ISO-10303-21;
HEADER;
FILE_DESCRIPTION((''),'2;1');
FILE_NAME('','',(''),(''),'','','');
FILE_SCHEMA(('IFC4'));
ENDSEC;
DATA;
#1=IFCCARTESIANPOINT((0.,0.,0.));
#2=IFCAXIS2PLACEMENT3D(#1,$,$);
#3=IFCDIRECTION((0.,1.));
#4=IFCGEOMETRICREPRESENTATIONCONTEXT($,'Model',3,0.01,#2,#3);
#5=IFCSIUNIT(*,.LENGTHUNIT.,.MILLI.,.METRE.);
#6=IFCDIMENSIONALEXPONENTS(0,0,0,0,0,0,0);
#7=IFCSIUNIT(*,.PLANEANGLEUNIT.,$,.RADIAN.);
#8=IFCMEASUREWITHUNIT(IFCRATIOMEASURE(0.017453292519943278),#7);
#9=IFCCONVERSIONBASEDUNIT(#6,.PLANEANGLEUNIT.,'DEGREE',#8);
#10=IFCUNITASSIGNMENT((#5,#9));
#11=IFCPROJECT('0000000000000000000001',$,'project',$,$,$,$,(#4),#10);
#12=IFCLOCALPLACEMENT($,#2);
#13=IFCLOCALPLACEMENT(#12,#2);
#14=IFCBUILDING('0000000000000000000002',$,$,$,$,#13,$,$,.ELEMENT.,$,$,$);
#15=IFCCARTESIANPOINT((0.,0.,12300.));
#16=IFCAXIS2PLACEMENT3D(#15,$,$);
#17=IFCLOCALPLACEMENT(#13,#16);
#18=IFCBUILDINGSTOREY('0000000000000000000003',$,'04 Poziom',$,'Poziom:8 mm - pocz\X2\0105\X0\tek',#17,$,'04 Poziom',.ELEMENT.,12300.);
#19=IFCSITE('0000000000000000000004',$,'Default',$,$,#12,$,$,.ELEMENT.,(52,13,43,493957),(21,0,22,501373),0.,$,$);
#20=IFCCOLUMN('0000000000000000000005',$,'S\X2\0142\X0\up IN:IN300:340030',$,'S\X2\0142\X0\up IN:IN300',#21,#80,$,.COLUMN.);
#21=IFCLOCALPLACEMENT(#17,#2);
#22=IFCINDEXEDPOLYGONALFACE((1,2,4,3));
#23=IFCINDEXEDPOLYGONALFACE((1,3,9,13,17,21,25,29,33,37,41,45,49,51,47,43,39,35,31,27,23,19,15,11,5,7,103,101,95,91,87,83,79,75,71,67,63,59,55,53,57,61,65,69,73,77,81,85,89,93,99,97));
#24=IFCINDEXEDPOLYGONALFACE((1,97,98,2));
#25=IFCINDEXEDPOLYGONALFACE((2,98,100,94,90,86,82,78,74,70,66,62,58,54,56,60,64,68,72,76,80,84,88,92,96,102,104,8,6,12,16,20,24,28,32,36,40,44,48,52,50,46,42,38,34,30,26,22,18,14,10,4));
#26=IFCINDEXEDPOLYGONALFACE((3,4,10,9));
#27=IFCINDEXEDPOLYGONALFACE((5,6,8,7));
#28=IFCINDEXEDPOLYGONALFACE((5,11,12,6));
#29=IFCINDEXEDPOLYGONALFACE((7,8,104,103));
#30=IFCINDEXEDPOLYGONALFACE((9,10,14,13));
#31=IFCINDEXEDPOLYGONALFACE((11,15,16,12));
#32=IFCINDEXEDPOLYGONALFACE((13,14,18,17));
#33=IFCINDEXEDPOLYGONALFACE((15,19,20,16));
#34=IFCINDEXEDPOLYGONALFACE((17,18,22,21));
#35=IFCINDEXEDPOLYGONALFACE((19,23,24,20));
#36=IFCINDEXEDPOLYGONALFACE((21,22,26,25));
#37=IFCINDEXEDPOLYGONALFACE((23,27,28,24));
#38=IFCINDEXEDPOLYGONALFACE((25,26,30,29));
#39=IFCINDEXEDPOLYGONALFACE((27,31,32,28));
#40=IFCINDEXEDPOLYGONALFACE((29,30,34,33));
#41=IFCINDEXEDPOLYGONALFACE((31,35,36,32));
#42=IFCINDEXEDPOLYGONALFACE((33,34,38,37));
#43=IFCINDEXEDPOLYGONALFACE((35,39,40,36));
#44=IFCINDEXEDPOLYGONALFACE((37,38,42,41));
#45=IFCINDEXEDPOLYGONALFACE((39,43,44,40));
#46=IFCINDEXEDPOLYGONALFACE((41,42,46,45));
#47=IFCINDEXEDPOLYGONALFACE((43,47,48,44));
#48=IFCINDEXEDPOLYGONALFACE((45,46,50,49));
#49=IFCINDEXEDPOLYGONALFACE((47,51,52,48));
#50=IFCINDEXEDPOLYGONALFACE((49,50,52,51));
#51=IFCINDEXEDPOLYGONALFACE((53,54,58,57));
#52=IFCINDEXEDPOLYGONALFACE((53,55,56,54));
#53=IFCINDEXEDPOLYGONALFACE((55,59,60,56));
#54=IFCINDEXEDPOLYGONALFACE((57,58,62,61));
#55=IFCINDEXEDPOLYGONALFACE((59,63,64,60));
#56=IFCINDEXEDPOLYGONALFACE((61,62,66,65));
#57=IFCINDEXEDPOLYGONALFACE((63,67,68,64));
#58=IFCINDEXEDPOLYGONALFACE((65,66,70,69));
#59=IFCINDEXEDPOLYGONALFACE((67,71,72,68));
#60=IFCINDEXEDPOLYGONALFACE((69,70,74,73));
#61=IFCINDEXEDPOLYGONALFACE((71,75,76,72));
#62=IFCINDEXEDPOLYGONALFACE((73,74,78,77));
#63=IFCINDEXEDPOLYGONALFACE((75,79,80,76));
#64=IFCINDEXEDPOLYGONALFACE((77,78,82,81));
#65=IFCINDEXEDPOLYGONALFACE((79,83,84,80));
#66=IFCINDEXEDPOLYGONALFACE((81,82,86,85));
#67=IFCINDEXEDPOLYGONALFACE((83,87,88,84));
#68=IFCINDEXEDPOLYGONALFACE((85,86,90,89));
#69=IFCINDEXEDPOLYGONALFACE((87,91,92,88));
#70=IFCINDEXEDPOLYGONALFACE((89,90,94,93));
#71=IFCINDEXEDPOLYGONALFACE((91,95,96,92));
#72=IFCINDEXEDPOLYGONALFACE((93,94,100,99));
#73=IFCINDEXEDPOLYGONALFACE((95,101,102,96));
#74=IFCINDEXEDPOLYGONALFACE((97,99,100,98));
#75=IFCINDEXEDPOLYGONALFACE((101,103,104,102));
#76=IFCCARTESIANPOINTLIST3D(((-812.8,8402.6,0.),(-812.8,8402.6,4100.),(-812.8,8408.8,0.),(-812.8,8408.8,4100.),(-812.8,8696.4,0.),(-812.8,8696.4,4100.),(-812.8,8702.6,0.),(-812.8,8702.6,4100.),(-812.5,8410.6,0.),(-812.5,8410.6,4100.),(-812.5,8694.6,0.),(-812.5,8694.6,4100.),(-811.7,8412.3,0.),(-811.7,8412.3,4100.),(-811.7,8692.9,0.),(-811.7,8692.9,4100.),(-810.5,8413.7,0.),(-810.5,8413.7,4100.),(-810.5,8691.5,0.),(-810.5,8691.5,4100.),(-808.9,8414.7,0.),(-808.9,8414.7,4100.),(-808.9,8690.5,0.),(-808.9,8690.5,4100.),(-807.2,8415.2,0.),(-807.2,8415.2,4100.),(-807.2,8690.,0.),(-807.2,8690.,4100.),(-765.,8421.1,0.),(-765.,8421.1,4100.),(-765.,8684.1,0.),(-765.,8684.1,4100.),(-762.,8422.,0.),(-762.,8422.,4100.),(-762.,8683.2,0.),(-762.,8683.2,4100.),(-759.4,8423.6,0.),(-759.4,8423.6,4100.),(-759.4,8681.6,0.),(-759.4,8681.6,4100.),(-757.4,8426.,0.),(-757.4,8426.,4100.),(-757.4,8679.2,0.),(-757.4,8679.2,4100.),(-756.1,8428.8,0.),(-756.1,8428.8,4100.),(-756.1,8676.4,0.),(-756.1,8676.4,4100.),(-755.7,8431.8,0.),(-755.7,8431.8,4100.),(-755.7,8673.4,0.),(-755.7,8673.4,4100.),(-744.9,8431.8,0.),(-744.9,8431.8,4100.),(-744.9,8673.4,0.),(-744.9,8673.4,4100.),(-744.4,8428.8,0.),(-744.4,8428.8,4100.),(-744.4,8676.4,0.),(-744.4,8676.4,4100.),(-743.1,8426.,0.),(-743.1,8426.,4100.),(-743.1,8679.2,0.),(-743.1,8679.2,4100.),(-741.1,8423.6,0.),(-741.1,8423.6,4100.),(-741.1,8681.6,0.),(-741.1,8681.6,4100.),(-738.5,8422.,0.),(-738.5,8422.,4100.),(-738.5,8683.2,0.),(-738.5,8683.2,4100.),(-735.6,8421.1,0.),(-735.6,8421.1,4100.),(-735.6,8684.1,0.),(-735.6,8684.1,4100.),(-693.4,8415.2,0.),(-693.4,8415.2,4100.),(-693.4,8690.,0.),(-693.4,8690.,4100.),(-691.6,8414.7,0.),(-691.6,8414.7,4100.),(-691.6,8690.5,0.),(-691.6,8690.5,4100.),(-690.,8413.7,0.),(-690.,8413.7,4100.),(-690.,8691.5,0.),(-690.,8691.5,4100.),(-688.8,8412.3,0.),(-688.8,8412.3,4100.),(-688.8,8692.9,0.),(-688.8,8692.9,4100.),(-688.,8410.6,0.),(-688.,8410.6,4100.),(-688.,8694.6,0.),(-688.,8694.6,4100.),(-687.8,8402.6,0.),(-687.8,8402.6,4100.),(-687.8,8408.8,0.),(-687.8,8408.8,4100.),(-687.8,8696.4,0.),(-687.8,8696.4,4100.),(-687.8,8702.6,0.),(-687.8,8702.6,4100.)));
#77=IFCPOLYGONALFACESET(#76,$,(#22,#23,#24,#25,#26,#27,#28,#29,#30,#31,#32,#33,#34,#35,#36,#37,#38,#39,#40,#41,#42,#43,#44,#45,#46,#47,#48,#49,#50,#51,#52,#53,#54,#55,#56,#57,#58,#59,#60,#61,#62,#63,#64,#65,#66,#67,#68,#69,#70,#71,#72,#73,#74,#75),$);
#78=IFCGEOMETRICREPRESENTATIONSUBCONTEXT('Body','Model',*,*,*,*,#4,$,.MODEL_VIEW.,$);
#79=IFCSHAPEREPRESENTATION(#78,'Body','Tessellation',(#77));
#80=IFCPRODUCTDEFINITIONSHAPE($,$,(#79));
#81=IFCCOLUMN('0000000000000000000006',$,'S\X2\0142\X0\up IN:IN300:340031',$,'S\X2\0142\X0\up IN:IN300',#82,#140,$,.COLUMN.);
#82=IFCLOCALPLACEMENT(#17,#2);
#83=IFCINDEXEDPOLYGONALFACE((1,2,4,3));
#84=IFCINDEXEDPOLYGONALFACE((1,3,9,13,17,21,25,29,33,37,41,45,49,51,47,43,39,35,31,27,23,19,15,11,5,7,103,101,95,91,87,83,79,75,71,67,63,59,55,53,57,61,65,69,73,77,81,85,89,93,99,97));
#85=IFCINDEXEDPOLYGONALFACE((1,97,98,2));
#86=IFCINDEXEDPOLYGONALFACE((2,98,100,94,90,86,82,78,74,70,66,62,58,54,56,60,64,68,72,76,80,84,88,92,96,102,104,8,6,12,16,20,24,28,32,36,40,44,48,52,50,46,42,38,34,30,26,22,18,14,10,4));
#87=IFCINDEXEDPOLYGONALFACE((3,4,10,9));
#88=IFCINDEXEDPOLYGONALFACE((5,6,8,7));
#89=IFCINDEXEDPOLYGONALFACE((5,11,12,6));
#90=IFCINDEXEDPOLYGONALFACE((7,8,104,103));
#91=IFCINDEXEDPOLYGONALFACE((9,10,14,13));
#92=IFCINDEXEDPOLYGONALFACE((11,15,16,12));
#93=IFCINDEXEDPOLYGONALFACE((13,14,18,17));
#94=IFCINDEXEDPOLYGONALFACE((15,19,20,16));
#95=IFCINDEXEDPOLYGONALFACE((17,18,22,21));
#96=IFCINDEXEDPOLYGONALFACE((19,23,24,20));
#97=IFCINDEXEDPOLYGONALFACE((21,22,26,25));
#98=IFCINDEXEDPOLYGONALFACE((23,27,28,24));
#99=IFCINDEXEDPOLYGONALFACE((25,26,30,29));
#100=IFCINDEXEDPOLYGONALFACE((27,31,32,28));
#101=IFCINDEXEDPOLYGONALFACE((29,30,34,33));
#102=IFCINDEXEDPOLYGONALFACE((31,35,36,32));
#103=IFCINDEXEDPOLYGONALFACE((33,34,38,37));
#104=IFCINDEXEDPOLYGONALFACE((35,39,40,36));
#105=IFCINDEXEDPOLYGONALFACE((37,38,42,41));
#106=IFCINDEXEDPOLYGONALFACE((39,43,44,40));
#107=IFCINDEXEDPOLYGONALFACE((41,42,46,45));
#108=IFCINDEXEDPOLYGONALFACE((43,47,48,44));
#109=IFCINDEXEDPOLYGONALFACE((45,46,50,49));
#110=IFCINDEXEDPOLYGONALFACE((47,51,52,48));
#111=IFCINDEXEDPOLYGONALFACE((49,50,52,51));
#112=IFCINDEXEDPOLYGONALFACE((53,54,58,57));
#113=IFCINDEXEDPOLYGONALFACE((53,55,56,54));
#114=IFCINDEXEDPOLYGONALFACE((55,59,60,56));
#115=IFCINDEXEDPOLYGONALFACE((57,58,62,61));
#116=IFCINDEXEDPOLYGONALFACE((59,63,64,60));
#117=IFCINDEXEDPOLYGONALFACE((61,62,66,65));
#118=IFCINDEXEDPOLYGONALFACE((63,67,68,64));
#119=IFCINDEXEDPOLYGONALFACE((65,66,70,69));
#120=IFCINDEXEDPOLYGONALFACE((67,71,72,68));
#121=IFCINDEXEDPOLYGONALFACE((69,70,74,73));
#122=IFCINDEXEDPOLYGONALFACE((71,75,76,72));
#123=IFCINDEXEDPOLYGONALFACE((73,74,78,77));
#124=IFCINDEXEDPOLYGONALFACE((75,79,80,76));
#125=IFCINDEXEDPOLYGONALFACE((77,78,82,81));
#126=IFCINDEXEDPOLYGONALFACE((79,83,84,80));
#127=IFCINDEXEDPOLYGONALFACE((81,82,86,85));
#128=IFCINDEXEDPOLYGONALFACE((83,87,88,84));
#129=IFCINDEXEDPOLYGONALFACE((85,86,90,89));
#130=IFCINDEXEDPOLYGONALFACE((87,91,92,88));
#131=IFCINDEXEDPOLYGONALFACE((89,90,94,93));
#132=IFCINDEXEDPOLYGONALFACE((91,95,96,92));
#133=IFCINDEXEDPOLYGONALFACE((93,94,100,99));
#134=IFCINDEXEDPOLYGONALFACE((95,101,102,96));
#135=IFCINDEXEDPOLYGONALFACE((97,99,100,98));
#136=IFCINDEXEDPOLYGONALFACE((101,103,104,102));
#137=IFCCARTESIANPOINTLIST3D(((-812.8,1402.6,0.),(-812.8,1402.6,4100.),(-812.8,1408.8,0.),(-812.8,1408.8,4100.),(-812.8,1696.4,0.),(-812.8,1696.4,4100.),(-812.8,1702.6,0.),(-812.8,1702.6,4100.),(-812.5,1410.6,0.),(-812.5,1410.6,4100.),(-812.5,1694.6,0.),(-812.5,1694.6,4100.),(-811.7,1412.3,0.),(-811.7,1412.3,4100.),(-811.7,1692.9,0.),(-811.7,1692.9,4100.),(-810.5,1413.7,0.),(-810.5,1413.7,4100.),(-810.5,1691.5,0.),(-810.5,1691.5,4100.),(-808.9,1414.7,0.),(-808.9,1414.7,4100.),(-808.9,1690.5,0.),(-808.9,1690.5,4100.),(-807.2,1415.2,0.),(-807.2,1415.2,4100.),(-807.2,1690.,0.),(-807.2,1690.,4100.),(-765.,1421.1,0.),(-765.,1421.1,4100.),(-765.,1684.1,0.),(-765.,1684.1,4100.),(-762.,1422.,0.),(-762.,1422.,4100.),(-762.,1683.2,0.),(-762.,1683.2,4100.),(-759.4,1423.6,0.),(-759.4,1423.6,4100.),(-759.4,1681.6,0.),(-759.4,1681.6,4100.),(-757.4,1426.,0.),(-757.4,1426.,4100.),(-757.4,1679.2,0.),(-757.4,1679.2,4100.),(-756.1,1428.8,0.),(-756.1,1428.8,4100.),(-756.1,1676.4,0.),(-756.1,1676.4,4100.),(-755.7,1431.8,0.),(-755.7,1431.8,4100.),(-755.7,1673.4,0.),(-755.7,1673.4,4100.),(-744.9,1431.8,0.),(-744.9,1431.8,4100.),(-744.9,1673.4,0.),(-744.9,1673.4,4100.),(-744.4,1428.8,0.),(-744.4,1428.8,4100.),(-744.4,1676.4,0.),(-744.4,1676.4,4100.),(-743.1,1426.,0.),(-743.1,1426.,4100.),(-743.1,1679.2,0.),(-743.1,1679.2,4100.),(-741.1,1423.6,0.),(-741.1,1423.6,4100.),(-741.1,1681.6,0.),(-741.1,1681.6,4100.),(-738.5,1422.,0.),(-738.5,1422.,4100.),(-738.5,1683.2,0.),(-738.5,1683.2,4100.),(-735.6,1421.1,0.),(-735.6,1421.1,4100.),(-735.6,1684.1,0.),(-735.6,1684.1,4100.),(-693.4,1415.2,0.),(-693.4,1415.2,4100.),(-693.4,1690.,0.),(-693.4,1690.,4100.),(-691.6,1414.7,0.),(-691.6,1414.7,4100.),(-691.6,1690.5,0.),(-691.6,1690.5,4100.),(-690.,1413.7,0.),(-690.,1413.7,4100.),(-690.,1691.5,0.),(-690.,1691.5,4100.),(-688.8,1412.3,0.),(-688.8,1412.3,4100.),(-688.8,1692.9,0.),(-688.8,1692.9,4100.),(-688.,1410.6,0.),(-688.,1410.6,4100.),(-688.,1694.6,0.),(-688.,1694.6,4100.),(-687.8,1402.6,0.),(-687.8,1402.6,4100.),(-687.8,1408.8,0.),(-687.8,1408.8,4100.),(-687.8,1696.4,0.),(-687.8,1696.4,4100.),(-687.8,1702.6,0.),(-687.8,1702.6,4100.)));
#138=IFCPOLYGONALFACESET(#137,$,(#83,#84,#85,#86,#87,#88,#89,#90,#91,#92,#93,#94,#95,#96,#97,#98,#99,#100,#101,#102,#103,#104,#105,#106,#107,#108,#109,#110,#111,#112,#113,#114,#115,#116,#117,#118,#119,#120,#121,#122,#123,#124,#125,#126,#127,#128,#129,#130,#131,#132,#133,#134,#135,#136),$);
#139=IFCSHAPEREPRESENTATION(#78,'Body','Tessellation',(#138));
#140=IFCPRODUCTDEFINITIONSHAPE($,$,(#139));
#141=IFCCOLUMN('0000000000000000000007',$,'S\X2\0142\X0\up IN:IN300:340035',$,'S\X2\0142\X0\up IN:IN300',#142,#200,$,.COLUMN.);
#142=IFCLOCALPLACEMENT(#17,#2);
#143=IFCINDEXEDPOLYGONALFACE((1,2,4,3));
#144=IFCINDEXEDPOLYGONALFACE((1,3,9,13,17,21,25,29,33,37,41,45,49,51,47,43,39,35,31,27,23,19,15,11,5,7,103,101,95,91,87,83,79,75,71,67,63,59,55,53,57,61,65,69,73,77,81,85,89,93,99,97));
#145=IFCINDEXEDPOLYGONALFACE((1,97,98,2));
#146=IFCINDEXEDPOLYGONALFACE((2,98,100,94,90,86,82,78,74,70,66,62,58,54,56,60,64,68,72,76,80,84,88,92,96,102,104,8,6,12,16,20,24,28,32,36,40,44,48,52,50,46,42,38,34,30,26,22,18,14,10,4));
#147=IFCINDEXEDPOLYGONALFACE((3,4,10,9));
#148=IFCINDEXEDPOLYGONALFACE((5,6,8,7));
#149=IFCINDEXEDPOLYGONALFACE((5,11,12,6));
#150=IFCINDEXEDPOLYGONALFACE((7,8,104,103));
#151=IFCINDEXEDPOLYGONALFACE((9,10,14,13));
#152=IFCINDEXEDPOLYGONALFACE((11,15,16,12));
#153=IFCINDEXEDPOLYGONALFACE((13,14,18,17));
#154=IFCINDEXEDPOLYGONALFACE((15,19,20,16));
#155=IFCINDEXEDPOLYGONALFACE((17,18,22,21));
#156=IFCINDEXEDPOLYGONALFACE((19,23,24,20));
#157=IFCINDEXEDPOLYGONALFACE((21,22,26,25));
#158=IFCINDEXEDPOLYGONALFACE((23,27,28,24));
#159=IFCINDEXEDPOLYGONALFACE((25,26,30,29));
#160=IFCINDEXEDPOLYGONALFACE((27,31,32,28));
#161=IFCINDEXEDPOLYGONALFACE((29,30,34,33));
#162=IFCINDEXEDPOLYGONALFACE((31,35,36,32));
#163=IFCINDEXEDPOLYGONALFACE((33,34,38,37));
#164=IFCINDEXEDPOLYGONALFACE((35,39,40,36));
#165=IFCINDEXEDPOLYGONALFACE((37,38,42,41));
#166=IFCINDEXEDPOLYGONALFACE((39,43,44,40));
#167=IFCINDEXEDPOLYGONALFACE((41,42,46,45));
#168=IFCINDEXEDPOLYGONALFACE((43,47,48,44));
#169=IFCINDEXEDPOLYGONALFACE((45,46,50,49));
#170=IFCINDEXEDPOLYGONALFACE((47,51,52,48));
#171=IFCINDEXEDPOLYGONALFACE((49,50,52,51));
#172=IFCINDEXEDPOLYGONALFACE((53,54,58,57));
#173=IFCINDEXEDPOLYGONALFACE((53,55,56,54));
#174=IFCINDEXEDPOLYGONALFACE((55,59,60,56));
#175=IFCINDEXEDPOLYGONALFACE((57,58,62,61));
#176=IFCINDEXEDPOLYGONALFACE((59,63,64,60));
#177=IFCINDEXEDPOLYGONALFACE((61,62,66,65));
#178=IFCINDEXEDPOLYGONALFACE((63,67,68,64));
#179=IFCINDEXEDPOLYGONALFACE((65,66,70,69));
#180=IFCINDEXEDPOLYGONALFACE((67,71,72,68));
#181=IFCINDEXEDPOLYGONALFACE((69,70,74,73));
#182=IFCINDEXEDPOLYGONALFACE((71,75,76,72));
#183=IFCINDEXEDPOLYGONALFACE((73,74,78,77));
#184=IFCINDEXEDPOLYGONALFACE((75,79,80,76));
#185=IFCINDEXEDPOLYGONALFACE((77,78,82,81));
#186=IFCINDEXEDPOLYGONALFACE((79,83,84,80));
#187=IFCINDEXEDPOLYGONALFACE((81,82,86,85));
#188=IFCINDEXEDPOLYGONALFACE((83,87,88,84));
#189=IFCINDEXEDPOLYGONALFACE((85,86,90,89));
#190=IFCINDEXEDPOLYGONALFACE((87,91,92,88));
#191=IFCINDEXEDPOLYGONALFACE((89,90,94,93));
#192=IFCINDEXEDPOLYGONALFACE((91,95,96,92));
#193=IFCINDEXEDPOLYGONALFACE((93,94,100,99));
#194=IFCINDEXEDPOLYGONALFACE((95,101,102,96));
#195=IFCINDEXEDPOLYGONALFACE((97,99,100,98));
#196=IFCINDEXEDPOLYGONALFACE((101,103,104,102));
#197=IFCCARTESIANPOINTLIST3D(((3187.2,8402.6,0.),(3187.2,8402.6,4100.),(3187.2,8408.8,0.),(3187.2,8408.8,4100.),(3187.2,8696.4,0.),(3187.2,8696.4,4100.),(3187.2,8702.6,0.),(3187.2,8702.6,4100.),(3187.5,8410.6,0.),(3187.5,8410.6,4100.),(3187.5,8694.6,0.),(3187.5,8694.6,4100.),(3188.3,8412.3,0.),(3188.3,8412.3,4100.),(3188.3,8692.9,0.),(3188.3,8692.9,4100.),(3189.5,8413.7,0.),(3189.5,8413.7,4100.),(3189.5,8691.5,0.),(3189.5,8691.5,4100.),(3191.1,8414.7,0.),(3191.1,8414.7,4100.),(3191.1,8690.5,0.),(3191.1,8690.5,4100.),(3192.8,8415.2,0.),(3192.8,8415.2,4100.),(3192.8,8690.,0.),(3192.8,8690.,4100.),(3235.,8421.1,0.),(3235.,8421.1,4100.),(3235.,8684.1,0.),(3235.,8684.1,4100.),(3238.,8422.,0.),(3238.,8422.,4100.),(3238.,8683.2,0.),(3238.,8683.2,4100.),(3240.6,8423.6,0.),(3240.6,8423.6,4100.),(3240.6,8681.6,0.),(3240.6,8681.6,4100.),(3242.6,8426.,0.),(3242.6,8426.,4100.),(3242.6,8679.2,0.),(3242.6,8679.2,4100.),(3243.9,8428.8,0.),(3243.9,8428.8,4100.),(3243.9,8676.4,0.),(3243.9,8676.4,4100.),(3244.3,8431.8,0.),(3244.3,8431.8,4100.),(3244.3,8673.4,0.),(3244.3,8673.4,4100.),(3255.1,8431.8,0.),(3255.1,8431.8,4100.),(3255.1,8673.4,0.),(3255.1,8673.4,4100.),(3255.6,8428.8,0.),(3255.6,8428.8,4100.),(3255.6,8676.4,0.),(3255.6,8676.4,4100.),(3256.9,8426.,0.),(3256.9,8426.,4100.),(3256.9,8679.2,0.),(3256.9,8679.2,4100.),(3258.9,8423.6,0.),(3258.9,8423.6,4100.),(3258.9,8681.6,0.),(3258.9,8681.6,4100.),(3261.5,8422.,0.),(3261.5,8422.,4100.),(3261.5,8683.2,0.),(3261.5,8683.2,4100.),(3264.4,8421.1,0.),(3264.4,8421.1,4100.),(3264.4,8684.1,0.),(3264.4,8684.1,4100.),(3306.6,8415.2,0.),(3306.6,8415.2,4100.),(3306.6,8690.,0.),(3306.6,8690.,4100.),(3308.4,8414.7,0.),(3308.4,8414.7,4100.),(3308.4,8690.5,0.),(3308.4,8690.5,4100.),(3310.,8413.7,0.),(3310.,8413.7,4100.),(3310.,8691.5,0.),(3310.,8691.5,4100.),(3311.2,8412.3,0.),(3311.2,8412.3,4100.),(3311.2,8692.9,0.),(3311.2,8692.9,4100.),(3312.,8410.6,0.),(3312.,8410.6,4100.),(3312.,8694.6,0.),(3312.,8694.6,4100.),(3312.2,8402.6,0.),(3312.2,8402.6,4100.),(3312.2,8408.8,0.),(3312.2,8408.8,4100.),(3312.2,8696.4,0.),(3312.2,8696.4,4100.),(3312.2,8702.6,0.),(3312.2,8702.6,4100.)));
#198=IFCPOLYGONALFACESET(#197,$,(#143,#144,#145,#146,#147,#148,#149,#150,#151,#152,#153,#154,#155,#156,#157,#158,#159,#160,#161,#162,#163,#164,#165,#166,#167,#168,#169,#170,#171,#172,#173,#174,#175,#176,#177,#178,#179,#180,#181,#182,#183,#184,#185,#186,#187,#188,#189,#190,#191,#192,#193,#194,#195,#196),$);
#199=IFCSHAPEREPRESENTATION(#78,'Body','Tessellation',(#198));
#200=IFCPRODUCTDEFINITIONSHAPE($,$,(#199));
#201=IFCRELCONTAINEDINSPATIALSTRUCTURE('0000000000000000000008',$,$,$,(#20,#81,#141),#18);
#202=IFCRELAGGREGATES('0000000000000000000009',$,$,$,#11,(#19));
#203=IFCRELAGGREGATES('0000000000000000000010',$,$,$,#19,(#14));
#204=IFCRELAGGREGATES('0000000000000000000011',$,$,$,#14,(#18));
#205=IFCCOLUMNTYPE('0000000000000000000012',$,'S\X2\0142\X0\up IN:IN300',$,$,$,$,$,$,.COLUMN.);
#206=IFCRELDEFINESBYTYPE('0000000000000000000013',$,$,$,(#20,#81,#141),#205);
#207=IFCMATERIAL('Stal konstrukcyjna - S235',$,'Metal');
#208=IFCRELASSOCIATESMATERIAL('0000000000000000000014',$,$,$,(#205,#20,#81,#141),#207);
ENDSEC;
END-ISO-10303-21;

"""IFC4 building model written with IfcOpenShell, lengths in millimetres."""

from ifc_helpers import new_model, entity, si_unit, converted_unit, direction, frame, origin, place, context, subcontext, project, spatial, line, arc, indexed_curve, outline, extrude, source, transform, mapped, material, type_object, type_shapes, element, save


model = new_model("IFC4")

# Units and contexts
model_context = context("Model", 3, precision=0.01, world=origin(), true_north=direction((0.0, 1.0)))
body_context = subcontext(model_context, "Body", "Model", "MODEL_VIEW")
ifc_project = project(units=[si_unit("LENGTHUNIT", "METRE", prefix="MILLI"), converted_unit("PLANEANGLEUNIT", "DEGREE", entity("IfcRatioMeasure", 0.017453292519943278), si_unit("PLANEANGLEUNIT", "RADIAN"), dimensions=[0, 0, 0, 0, 0, 0, 0])], contexts=[model_context])

# Site, building, storey
site_placement = place(None, origin())
site = spatial("IfcSite", under=ifc_project, at=site_placement, Name="Default", CompositionType="ELEMENT", RefLatitude=(52, 13, 43, 493957), RefLongitude=(21, 0, 22, 501373), RefElevation=0.0)
building_placement = place(site_placement, origin())
building = spatial("IfcBuilding", under=site, at=building_placement, CompositionType="ELEMENT")
storey_placement = place(building_placement, frame((0.0, 0.0, 12300.0)))
storey = spatial("IfcBuildingStorey", under=building, at=storey_placement, Name="04 Poziom", ObjectType="Poziom:8 mm - początek", LongName="04 Poziom", CompositionType="ELEMENT", Elevation=12300.0)

# Columns
ifc_material_1 = material(Name="Stal konstrukcyjna - S235", Category="Metal")
column_type = type_object("IfcColumnType", Name="Słup IN:IN300", PredefinedType="COLUMN", material=ifc_material_1)
shared_shape_1 = source(origin(), body_context, "Body", "SweptSolid", [
    extrude(outline(indexed_curve([(143.8, -62.5), (150.0, -62.5), (150.0, 62.5), (143.8, 62.5), (139.6, 60.9), (137.4, 56.9), (131.5, 14.7), (127.9, 8.1), (120.8, 5.4), (-120.8, 5.4), (-127.9, 8.1), (-131.5, 14.7), (-137.4, 56.9), (-139.6, 60.9), (-143.8, 62.5), (-150.0, 62.5), (-150.0, -62.5), (-143.8, -62.5), (-139.6, -60.9), (-137.4, -56.9), (-131.5, -14.7), (-127.9, -8.1), (-120.8, -5.4), (120.8, -5.4), (127.9, -8.1), (131.5, -14.7), (137.4, -56.9), (139.6, -60.9)], segments=[line(1, 2, 3, 4), arc(4, 5, 6), line(6, 7), arc(7, 8, 9), line(9, 10), arc(10, 11, 12), line(12, 13), arc(13, 14, 15), line(15, 16, 17, 18), arc(18, 19, 20), line(20, 21), arc(21, 22, 23), line(23, 24), arc(24, 25, 26), line(26, 27), arc(27, 28, 1)], self_intersect=False)), frame((0.0, 0.0, 12300.0), z_axis=(0.0, 0.0, 1.0), x_axis=(0.0, -1.0, 0.0)), (0.0, 0.0, 1.0), 4100.0),
])
type_shapes(column_type, [shared_shape_1])
for number, where, name in (
    (1, (-750.3, 8552.6, -12300.0), "Słup IN:IN300:340030"),
    (2, (-750.3, 1552.6, -12300.0), "Słup IN:IN300:340031"),
    (3, (3249.7, 8552.6, -12300.0), "Słup IN:IN300:340035"),
):
    element("IfcColumn", number, at=place(storey_placement, frame(where)), inside=storey, type_object=column_type, material=ifc_material_1, Name=name, ObjectType="Słup IN:IN300", PredefinedType="COLUMN", context=body_context, shape_type="MappedRepresentation", body=[
        mapped(shared_shape_1, transform((0.0, 0.0, 0.0), scale=1.0)),
    ])

save(model, "model.ifc")
